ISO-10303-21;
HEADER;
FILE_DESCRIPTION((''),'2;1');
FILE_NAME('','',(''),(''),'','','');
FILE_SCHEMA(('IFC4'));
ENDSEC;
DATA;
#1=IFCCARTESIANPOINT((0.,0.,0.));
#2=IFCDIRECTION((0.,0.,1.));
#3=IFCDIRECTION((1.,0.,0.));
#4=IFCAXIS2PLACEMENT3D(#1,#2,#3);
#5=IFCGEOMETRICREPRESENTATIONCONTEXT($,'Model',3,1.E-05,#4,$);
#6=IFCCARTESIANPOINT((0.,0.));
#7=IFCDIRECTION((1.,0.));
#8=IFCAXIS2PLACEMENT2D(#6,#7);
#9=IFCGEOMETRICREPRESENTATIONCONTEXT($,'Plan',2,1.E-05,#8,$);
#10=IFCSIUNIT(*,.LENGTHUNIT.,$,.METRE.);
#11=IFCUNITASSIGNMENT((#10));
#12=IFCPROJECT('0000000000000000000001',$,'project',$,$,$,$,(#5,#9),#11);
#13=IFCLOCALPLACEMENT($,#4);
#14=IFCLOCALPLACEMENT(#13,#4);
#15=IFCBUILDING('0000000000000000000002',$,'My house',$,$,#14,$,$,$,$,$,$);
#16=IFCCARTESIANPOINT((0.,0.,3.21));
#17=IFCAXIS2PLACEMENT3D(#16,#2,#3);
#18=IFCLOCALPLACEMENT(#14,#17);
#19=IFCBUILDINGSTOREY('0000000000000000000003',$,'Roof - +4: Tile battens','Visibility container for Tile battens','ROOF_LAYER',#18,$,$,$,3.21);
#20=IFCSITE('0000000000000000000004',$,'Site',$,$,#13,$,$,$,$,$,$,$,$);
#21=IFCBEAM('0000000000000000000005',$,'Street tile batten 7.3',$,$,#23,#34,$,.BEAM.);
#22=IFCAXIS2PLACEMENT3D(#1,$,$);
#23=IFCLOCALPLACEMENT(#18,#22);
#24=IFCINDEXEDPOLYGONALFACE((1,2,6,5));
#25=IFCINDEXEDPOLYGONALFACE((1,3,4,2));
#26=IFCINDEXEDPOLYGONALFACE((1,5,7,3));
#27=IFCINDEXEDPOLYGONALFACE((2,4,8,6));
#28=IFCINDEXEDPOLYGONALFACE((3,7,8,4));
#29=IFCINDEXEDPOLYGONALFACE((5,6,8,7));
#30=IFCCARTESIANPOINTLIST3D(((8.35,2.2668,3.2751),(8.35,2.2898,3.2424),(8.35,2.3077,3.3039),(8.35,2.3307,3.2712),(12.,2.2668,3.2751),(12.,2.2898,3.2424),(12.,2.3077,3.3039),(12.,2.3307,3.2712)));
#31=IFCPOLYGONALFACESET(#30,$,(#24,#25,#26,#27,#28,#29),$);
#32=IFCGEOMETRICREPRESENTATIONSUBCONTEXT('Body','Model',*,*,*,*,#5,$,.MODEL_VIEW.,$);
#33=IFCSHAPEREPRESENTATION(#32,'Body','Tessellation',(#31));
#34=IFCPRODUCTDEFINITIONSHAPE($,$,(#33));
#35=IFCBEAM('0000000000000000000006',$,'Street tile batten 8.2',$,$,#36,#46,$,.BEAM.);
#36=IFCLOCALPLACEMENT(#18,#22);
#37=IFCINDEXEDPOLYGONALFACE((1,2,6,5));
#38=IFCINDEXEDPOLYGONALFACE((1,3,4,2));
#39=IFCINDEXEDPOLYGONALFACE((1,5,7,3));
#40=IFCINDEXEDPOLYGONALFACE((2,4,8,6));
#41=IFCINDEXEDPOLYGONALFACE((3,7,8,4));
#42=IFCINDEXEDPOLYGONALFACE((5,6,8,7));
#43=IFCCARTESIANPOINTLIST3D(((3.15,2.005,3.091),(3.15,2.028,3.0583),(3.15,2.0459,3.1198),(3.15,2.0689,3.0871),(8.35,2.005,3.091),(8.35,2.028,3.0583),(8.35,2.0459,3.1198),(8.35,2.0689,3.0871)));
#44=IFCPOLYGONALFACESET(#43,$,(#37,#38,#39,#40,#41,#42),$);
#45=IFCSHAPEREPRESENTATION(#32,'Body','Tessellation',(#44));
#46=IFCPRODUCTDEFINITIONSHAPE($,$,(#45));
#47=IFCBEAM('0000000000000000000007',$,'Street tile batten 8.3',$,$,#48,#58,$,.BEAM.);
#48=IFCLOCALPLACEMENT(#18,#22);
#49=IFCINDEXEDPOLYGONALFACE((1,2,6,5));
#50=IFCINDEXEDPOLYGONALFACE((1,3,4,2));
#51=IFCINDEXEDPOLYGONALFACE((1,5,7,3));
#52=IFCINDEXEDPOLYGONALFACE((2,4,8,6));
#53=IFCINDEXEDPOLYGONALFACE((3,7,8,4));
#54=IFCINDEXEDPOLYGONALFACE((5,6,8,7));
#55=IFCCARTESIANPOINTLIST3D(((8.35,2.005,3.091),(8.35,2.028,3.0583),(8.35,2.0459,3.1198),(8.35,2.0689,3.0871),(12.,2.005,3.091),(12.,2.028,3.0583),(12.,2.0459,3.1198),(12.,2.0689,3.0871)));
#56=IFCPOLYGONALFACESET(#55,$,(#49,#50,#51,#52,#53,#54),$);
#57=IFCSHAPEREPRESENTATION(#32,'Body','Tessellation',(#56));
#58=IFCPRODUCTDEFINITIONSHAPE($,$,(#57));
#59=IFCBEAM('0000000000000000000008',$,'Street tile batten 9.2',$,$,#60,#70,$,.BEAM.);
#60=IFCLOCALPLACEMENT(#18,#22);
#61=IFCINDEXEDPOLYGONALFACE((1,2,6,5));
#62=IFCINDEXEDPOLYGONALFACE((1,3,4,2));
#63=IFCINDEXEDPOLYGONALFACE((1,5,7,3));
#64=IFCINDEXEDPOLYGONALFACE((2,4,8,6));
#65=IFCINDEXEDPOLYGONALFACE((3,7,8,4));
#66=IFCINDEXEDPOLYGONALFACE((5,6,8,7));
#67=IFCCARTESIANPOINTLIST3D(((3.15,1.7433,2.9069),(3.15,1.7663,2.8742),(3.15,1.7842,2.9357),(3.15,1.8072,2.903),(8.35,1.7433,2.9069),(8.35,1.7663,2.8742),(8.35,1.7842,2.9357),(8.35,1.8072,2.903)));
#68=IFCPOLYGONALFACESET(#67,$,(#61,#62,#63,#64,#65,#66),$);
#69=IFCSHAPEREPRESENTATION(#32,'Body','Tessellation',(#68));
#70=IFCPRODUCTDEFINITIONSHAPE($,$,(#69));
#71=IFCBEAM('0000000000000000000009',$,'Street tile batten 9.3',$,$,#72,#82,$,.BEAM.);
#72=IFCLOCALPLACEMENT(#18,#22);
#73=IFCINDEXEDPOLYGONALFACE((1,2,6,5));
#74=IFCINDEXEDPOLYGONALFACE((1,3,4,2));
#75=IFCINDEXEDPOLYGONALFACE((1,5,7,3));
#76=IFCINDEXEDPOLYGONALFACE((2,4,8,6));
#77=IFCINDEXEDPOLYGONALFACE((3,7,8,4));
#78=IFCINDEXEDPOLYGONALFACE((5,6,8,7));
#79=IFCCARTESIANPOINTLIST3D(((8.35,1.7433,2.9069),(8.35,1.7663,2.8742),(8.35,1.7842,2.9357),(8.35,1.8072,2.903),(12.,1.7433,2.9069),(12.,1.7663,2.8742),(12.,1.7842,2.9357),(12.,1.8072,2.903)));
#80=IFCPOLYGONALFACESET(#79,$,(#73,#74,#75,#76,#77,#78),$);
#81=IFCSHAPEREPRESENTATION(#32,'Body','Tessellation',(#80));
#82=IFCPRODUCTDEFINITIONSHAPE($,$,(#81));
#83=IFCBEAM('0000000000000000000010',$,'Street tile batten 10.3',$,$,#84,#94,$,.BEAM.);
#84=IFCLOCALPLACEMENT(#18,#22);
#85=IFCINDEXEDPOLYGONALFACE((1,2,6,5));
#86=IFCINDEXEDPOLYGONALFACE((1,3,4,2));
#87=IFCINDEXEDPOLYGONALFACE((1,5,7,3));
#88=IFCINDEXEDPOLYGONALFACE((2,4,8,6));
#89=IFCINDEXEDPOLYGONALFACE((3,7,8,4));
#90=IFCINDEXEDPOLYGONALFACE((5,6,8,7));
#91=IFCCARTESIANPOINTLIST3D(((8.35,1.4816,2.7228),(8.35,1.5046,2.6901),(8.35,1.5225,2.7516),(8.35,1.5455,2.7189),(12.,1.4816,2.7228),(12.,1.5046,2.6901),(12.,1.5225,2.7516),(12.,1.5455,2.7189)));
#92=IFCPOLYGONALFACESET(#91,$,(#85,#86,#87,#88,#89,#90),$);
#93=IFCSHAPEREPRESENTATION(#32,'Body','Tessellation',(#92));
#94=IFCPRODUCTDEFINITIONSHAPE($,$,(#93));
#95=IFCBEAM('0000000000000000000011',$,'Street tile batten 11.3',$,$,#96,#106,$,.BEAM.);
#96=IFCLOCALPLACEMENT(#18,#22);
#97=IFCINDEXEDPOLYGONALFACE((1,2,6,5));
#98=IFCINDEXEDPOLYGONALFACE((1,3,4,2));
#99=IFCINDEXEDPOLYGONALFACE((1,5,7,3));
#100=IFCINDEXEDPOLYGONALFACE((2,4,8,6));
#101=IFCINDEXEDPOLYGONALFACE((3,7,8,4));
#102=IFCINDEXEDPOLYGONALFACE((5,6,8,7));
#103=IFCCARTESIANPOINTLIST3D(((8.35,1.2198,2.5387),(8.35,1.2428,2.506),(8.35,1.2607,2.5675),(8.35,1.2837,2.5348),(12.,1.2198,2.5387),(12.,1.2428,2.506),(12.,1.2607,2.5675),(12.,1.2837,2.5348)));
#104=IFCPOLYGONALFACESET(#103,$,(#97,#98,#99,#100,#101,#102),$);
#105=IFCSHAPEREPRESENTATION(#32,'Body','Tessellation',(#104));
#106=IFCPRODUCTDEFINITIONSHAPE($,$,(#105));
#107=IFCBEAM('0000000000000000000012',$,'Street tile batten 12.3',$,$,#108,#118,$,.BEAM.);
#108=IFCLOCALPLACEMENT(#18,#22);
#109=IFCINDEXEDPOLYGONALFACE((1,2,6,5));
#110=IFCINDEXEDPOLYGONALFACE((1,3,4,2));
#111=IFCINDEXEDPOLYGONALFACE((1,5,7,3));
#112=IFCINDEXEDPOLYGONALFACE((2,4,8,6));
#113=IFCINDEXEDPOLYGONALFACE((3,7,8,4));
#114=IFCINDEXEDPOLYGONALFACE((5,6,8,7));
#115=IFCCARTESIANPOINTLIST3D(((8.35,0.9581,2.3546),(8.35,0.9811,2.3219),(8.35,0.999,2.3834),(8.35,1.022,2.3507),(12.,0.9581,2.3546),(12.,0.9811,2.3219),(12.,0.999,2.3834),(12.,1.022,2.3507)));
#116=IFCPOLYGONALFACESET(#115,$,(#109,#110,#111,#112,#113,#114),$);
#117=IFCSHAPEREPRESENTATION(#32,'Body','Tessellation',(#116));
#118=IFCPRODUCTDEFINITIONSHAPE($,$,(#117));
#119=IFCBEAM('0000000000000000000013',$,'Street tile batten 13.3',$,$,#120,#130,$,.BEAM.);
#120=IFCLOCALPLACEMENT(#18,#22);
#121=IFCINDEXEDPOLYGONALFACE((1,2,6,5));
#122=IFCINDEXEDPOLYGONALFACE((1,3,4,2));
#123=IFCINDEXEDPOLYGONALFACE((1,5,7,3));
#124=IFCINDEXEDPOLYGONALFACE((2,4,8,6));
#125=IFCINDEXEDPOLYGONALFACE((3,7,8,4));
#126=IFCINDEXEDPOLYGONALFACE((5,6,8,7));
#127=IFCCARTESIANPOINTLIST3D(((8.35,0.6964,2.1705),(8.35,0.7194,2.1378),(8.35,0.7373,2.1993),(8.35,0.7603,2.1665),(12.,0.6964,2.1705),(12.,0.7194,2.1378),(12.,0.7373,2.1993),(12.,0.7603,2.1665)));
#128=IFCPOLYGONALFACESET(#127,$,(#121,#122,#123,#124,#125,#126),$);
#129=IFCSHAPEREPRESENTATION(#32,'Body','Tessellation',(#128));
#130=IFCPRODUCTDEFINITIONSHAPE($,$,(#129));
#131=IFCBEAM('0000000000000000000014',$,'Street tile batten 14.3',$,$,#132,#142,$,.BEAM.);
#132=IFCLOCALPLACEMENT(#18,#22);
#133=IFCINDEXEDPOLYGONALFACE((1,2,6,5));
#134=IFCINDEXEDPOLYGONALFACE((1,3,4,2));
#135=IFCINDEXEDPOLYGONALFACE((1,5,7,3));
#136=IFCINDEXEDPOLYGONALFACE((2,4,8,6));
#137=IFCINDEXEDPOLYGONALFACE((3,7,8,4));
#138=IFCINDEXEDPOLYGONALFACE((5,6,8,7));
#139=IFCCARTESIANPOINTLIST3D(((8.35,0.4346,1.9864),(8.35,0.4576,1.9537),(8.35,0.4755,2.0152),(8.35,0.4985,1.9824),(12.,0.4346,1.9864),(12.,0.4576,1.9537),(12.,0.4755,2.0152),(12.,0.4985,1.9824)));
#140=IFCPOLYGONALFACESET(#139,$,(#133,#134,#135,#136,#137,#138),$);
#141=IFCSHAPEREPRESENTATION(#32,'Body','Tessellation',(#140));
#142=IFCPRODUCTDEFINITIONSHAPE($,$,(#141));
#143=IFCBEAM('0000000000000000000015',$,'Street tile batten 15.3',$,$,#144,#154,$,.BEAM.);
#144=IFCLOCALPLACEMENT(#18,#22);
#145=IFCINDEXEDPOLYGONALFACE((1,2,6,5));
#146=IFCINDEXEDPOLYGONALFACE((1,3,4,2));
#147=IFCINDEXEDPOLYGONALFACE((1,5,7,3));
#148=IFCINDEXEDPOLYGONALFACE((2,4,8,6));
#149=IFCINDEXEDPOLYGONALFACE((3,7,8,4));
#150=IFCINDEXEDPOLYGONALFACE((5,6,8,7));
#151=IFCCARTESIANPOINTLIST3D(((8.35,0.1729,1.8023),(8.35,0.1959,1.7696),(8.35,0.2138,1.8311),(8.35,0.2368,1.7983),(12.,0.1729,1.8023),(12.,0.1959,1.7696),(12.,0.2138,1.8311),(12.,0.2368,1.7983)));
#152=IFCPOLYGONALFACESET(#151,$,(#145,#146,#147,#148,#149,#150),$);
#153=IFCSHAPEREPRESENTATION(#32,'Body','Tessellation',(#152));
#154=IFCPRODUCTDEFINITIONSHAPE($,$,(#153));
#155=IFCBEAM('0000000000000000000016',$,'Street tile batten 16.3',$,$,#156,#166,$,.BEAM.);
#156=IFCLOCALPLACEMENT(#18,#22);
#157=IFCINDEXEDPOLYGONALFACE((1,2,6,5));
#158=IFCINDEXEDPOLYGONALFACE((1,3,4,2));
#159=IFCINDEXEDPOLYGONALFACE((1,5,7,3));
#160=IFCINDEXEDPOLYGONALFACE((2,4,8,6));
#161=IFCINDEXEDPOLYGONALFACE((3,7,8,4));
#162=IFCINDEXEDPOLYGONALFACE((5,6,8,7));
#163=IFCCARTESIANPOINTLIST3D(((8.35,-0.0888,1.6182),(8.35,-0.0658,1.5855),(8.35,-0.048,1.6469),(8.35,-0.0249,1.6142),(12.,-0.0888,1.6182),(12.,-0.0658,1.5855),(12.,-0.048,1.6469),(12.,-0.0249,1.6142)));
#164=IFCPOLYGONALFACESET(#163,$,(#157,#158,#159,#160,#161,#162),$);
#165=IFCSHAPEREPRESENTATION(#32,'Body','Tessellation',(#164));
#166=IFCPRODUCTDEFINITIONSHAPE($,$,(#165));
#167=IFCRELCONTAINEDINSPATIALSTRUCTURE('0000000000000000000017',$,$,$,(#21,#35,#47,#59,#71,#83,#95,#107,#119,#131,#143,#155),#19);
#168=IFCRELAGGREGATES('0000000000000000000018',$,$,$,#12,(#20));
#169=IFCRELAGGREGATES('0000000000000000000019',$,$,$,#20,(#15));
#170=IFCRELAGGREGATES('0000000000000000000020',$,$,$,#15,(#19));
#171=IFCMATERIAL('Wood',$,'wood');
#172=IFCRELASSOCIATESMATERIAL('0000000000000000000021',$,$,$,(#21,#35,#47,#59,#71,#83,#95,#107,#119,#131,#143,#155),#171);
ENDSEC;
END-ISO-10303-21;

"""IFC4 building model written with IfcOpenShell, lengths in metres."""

from ifc_helpers import new_model, si_unit, frame, origin_with_axes, origin_2d_with_axis, place, context, subcontext, project, spatial, rectangle, extrude, clip, halfspace, material, element, save


model = new_model("IFC4")

# Units and contexts
model_context = context("Model", 3, precision=1e-05, world=origin_with_axes())
plan_context = context("Plan", 2, precision=1e-05, world=origin_2d_with_axis())
body_context = subcontext(model_context, "Body", "Model", "MODEL_VIEW")
ifc_project = project(units=[si_unit("LENGTHUNIT", "METRE")], contexts=[model_context, plan_context])

# Site, building, storey
site_placement = place(None, origin_with_axes())
site = spatial("IfcSite", under=ifc_project, at=site_placement, Name="Site")
building_placement = place(site_placement, origin_with_axes())
building = spatial("IfcBuilding", under=site, at=building_placement, Name="My house")
storey_placement = place(building_placement, frame((0.0, 0.0, 3.21), z_axis=(0.0, 0.0, 1.0), x_axis=(1.0, 0.0, 0.0)))
storey = spatial("IfcBuildingStorey", under=building, at=storey_placement, Name="Roof - +4: Tile battens", Description="Visibility container for Tile battens", ObjectType="ROOF_LAYER", Elevation=3.21)

# Beams
ifc_material = material(Name="Wood", Category="wood")
beam_1_placement = place(storey_placement, frame((8.35, 2.2987, 3.2732), z_axis=(0.0, -0.575329, 0.817922), x_axis=(1.0, 0.0, 0.0)))
element("IfcBeam", 1, at=beam_1_placement, inside=storey, material=ifc_material, Name="Street tile batten 7.3", PredefinedType="BEAM", context=body_context, shape_type="Clipping", body=[
    clip(clip(extrude(rectangle(XDim=0.05, YDim=0.04), frame((0.0, 0.0, 0.0), z_axis=(1.0, 0.0, 0.0), x_axis=(0.0, 1.0, 0.0)), (0.0, 0.0, 1.0), 3.65), halfspace(frame((-8.35, -2.3384, -6.2815), z_axis=(0.0, 0.817922, -0.575329), x_axis=(1.0, 0.0, 0.0)), False)), halfspace(frame((-8.35, -5.9373, -3.7501), z_axis=(0.0, -0.817922, 0.575329), x_axis=(-1.0, 0.0, 0.0)), False)),
])
beam_2_placement = place(storey_placement, frame((3.15, 2.037, 3.089), z_axis=(0.0, -0.575329, 0.817922), x_axis=(1.0, 0.0, 0.0)))
element("IfcBeam", 2, at=beam_2_placement, inside=storey, material=ifc_material, Name="Street tile batten 8.2", PredefinedType="BEAM", context=body_context, shape_type="Clipping", body=[
    clip(clip(extrude(rectangle(XDim=0.05, YDim=0.04), frame((0.0, 0.0, 0.0), z_axis=(1.0, 0.0, 0.0), x_axis=(0.0, 1.0, 0.0)), (0.0, 0.0, 1.0), 5.2), halfspace(frame((-3.15, -2.0184, -6.2815), z_axis=(0.0, 0.817922, -0.575329), x_axis=(1.0, 0.0, 0.0)), False)), halfspace(frame((-3.15, -5.6173, -3.7501), z_axis=(0.0, -0.817922, 0.575329), x_axis=(-1.0, 0.0, 0.0)), False)),
])
beam_3_placement = place(storey_placement, frame((8.35, 2.037, 3.089), z_axis=(0.0, -0.575329, 0.817922), x_axis=(1.0, 0.0, 0.0)))
element("IfcBeam", 3, at=beam_3_placement, inside=storey, material=ifc_material, Name="Street tile batten 8.3", PredefinedType="BEAM", context=body_context, shape_type="Clipping", body=[
    clip(clip(extrude(rectangle(XDim=0.05, YDim=0.04), frame((0.0, 0.0, 0.0), z_axis=(1.0, 0.0, 0.0), x_axis=(0.0, 1.0, 0.0)), (0.0, 0.0, 1.0), 3.65), halfspace(frame((-8.35, -2.0184, -6.2815), z_axis=(0.0, 0.817922, -0.575329), x_axis=(1.0, 0.0, 0.0)), False)), halfspace(frame((-8.35, -5.6173, -3.7501), z_axis=(0.0, -0.817922, 0.575329), x_axis=(-1.0, 0.0, 0.0)), False)),
])
beam_4_placement = place(storey_placement, frame((3.15, 1.7753, 2.9049), z_axis=(0.0, -0.575329, 0.817922), x_axis=(1.0, 0.0, 0.0)))
element("IfcBeam", 4, at=beam_4_placement, inside=storey, material=ifc_material, Name="Street tile batten 9.2", PredefinedType="BEAM", context=body_context, shape_type="Clipping", body=[
    clip(clip(extrude(rectangle(XDim=0.05, YDim=0.04), frame((0.0, 0.0, 0.0), z_axis=(1.0, 0.0, 0.0), x_axis=(0.0, 1.0, 0.0)), (0.0, 0.0, 1.0), 5.2), halfspace(frame((-3.15, -1.6984, -6.2815), z_axis=(0.0, 0.817922, -0.575329), x_axis=(1.0, 0.0, 0.0)), False)), halfspace(frame((-3.15, -5.2973, -3.7501), z_axis=(0.0, -0.817922, 0.575329), x_axis=(-1.0, 0.0, 0.0)), False)),
])
beam_5_placement = place(storey_placement, frame((8.35, 1.7753, 2.9049), z_axis=(0.0, -0.575329, 0.817922), x_axis=(1.0, 0.0, 0.0)))
element("IfcBeam", 5, at=beam_5_placement, inside=storey, material=ifc_material, Name="Street tile batten 9.3", PredefinedType="BEAM", context=body_context, shape_type="Clipping", body=[
    clip(clip(extrude(rectangle(XDim=0.05, YDim=0.04), frame((0.0, 0.0, 0.0), z_axis=(1.0, 0.0, 0.0), x_axis=(0.0, 1.0, 0.0)), (0.0, 0.0, 1.0), 3.65), halfspace(frame((-8.35, -1.6984, -6.2815), z_axis=(0.0, 0.817922, -0.575329), x_axis=(1.0, 0.0, 0.0)), False)), halfspace(frame((-8.35, -5.2973, -3.7501), z_axis=(0.0, -0.817922, 0.575329), x_axis=(-1.0, 0.0, 0.0)), False)),
])
beam_6_placement = place(storey_placement, frame((8.35, 1.5135, 2.7208), z_axis=(0.0, -0.575329, 0.817922), x_axis=(1.0, 0.0, 0.0)))
element("IfcBeam", 6, at=beam_6_placement, inside=storey, material=ifc_material, Name="Street tile batten 10.3", PredefinedType="BEAM", context=body_context, shape_type="Clipping", body=[
    clip(clip(extrude(rectangle(XDim=0.05, YDim=0.04), frame((0.0, 0.0, 0.0), z_axis=(1.0, 0.0, 0.0), x_axis=(0.0, 1.0, 0.0)), (0.0, 0.0, 1.0), 3.65), halfspace(frame((-8.35, -1.3784, -6.2815), z_axis=(0.0, 0.817922, -0.575329), x_axis=(1.0, 0.0, 0.0)), False)), halfspace(frame((-8.35, -4.9773, -3.7501), z_axis=(0.0, -0.817922, 0.575329), x_axis=(-1.0, 0.0, 0.0)), False)),
])
beam_7_placement = place(storey_placement, frame((8.35, 1.2518, 2.5367), z_axis=(0.0, -0.575329, 0.817922), x_axis=(1.0, 0.0, 0.0)))
element("IfcBeam", 7, at=beam_7_placement, inside=storey, material=ifc_material, Name="Street tile batten 11.3", PredefinedType="BEAM", context=body_context, shape_type="Clipping", body=[
    clip(clip(extrude(rectangle(XDim=0.05, YDim=0.04), frame((0.0, 0.0, 0.0), z_axis=(1.0, 0.0, 0.0), x_axis=(0.0, 1.0, 0.0)), (0.0, 0.0, 1.0), 3.65), halfspace(frame((-8.35, -1.0584, -6.2815), z_axis=(0.0, 0.817922, -0.575329), x_axis=(1.0, 0.0, 0.0)), False)), halfspace(frame((-8.35, -4.6573, -3.7501), z_axis=(0.0, -0.817922, 0.575329), x_axis=(-1.0, 0.0, 0.0)), False)),
])
beam_8_placement = place(storey_placement, frame((8.35, 0.99, 2.3526), z_axis=(0.0, -0.575329, 0.817922), x_axis=(1.0, 0.0, 0.0)))
element("IfcBeam", 8, at=beam_8_placement, inside=storey, material=ifc_material, Name="Street tile batten 12.3", PredefinedType="BEAM", context=body_context, shape_type="Clipping", body=[
    clip(clip(extrude(rectangle(XDim=0.05, YDim=0.04), frame((0.0, 0.0, 0.0), z_axis=(1.0, 0.0, 0.0), x_axis=(0.0, 1.0, 0.0)), (0.0, 0.0, 1.0), 3.65), halfspace(frame((-8.35, -0.7384, -6.2815), z_axis=(0.0, 0.817922, -0.575329), x_axis=(1.0, 0.0, 0.0)), False)), halfspace(frame((-8.35, -4.3373, -3.7501), z_axis=(0.0, -0.817922, 0.575329), x_axis=(-1.0, 0.0, 0.0)), False)),
])
beam_9_placement = place(storey_placement, frame((8.35, 0.7283, 2.1685), z_axis=(0.0, -0.575329, 0.817922), x_axis=(1.0, 0.0, 0.0)))
element("IfcBeam", 9, at=beam_9_placement, inside=storey, material=ifc_material, Name="Street tile batten 13.3", PredefinedType="BEAM", context=body_context, shape_type="Clipping", body=[
    clip(clip(extrude(rectangle(XDim=0.05, YDim=0.04), frame((0.0, 0.0, 0.0), z_axis=(1.0, 0.0, 0.0), x_axis=(0.0, 1.0, 0.0)), (0.0, 0.0, 1.0), 3.65), halfspace(frame((-8.35, -0.4184, -6.2815), z_axis=(0.0, 0.817922, -0.575329), x_axis=(1.0, 0.0, 0.0)), False)), halfspace(frame((-8.35, -4.0173, -3.7501), z_axis=(0.0, -0.817922, 0.575329), x_axis=(-1.0, 0.0, 0.0)), False)),
])
beam_10_placement = place(storey_placement, frame((8.35, 0.4666, 1.9844), z_axis=(0.0, -0.575329, 0.817922), x_axis=(1.0, 0.0, 0.0)))
element("IfcBeam", 10, at=beam_10_placement, inside=storey, material=ifc_material, Name="Street tile batten 14.3", PredefinedType="BEAM", context=body_context, shape_type="Clipping", body=[
    clip(clip(extrude(rectangle(XDim=0.05, YDim=0.04), frame((0.0, 0.0, 0.0), z_axis=(1.0, 0.0, 0.0), x_axis=(0.0, 1.0, 0.0)), (0.0, 0.0, 1.0), 3.65), halfspace(frame((-8.35, -0.0984, -6.2815), z_axis=(0.0, 0.817922, -0.575329), x_axis=(1.0, 0.0, 0.0)), False)), halfspace(frame((-8.35, -3.6973, -3.7501), z_axis=(0.0, -0.817922, 0.575329), x_axis=(-1.0, 0.0, 0.0)), False)),
])
beam_11_placement = place(storey_placement, frame((8.35, 0.2048, 1.8003), z_axis=(0.0, -0.575329, 0.817922), x_axis=(1.0, 0.0, 0.0)))
element("IfcBeam", 11, at=beam_11_placement, inside=storey, material=ifc_material, Name="Street tile batten 15.3", PredefinedType="BEAM", context=body_context, shape_type="Clipping", body=[
    clip(clip(extrude(rectangle(XDim=0.05, YDim=0.04), frame((0.0, 0.0, 0.0), z_axis=(1.0, 0.0, 0.0), x_axis=(0.0, 1.0, 0.0)), (0.0, 0.0, 1.0), 3.65), halfspace(frame((-8.35, 0.2216, -6.2815), z_axis=(0.0, 0.817922, -0.575329), x_axis=(1.0, 0.0, 0.0)), False)), halfspace(frame((-8.35, -3.3773, -3.7501), z_axis=(0.0, -0.817922, 0.575329), x_axis=(-1.0, 0.0, 0.0)), False)),
])
beam_12_placement = place(storey_placement, frame((8.35, -0.0569, 1.6162), z_axis=(0.0, -0.575329, 0.817922), x_axis=(1.0, 0.0, 0.0)))
element("IfcBeam", 12, at=beam_12_placement, inside=storey, material=ifc_material, Name="Street tile batten 16.3", PredefinedType="BEAM", context=body_context, shape_type="Clipping", body=[
    clip(clip(extrude(rectangle(XDim=0.05, YDim=0.04), frame((0.0, 0.0, 0.0), z_axis=(1.0, 0.0, 0.0), x_axis=(0.0, 1.0, 0.0)), (0.0, 0.0, 1.0), 3.65), halfspace(frame((-8.35, 0.5416, -6.2815), z_axis=(0.0, 0.817922, -0.575329), x_axis=(1.0, 0.0, 0.0)), False)), halfspace(frame((-8.35, -3.0573, -3.7501), z_axis=(0.0, -0.817922, 0.575329), x_axis=(-1.0, 0.0, 0.0)), False)),
])

save(model, "model.ifc")
